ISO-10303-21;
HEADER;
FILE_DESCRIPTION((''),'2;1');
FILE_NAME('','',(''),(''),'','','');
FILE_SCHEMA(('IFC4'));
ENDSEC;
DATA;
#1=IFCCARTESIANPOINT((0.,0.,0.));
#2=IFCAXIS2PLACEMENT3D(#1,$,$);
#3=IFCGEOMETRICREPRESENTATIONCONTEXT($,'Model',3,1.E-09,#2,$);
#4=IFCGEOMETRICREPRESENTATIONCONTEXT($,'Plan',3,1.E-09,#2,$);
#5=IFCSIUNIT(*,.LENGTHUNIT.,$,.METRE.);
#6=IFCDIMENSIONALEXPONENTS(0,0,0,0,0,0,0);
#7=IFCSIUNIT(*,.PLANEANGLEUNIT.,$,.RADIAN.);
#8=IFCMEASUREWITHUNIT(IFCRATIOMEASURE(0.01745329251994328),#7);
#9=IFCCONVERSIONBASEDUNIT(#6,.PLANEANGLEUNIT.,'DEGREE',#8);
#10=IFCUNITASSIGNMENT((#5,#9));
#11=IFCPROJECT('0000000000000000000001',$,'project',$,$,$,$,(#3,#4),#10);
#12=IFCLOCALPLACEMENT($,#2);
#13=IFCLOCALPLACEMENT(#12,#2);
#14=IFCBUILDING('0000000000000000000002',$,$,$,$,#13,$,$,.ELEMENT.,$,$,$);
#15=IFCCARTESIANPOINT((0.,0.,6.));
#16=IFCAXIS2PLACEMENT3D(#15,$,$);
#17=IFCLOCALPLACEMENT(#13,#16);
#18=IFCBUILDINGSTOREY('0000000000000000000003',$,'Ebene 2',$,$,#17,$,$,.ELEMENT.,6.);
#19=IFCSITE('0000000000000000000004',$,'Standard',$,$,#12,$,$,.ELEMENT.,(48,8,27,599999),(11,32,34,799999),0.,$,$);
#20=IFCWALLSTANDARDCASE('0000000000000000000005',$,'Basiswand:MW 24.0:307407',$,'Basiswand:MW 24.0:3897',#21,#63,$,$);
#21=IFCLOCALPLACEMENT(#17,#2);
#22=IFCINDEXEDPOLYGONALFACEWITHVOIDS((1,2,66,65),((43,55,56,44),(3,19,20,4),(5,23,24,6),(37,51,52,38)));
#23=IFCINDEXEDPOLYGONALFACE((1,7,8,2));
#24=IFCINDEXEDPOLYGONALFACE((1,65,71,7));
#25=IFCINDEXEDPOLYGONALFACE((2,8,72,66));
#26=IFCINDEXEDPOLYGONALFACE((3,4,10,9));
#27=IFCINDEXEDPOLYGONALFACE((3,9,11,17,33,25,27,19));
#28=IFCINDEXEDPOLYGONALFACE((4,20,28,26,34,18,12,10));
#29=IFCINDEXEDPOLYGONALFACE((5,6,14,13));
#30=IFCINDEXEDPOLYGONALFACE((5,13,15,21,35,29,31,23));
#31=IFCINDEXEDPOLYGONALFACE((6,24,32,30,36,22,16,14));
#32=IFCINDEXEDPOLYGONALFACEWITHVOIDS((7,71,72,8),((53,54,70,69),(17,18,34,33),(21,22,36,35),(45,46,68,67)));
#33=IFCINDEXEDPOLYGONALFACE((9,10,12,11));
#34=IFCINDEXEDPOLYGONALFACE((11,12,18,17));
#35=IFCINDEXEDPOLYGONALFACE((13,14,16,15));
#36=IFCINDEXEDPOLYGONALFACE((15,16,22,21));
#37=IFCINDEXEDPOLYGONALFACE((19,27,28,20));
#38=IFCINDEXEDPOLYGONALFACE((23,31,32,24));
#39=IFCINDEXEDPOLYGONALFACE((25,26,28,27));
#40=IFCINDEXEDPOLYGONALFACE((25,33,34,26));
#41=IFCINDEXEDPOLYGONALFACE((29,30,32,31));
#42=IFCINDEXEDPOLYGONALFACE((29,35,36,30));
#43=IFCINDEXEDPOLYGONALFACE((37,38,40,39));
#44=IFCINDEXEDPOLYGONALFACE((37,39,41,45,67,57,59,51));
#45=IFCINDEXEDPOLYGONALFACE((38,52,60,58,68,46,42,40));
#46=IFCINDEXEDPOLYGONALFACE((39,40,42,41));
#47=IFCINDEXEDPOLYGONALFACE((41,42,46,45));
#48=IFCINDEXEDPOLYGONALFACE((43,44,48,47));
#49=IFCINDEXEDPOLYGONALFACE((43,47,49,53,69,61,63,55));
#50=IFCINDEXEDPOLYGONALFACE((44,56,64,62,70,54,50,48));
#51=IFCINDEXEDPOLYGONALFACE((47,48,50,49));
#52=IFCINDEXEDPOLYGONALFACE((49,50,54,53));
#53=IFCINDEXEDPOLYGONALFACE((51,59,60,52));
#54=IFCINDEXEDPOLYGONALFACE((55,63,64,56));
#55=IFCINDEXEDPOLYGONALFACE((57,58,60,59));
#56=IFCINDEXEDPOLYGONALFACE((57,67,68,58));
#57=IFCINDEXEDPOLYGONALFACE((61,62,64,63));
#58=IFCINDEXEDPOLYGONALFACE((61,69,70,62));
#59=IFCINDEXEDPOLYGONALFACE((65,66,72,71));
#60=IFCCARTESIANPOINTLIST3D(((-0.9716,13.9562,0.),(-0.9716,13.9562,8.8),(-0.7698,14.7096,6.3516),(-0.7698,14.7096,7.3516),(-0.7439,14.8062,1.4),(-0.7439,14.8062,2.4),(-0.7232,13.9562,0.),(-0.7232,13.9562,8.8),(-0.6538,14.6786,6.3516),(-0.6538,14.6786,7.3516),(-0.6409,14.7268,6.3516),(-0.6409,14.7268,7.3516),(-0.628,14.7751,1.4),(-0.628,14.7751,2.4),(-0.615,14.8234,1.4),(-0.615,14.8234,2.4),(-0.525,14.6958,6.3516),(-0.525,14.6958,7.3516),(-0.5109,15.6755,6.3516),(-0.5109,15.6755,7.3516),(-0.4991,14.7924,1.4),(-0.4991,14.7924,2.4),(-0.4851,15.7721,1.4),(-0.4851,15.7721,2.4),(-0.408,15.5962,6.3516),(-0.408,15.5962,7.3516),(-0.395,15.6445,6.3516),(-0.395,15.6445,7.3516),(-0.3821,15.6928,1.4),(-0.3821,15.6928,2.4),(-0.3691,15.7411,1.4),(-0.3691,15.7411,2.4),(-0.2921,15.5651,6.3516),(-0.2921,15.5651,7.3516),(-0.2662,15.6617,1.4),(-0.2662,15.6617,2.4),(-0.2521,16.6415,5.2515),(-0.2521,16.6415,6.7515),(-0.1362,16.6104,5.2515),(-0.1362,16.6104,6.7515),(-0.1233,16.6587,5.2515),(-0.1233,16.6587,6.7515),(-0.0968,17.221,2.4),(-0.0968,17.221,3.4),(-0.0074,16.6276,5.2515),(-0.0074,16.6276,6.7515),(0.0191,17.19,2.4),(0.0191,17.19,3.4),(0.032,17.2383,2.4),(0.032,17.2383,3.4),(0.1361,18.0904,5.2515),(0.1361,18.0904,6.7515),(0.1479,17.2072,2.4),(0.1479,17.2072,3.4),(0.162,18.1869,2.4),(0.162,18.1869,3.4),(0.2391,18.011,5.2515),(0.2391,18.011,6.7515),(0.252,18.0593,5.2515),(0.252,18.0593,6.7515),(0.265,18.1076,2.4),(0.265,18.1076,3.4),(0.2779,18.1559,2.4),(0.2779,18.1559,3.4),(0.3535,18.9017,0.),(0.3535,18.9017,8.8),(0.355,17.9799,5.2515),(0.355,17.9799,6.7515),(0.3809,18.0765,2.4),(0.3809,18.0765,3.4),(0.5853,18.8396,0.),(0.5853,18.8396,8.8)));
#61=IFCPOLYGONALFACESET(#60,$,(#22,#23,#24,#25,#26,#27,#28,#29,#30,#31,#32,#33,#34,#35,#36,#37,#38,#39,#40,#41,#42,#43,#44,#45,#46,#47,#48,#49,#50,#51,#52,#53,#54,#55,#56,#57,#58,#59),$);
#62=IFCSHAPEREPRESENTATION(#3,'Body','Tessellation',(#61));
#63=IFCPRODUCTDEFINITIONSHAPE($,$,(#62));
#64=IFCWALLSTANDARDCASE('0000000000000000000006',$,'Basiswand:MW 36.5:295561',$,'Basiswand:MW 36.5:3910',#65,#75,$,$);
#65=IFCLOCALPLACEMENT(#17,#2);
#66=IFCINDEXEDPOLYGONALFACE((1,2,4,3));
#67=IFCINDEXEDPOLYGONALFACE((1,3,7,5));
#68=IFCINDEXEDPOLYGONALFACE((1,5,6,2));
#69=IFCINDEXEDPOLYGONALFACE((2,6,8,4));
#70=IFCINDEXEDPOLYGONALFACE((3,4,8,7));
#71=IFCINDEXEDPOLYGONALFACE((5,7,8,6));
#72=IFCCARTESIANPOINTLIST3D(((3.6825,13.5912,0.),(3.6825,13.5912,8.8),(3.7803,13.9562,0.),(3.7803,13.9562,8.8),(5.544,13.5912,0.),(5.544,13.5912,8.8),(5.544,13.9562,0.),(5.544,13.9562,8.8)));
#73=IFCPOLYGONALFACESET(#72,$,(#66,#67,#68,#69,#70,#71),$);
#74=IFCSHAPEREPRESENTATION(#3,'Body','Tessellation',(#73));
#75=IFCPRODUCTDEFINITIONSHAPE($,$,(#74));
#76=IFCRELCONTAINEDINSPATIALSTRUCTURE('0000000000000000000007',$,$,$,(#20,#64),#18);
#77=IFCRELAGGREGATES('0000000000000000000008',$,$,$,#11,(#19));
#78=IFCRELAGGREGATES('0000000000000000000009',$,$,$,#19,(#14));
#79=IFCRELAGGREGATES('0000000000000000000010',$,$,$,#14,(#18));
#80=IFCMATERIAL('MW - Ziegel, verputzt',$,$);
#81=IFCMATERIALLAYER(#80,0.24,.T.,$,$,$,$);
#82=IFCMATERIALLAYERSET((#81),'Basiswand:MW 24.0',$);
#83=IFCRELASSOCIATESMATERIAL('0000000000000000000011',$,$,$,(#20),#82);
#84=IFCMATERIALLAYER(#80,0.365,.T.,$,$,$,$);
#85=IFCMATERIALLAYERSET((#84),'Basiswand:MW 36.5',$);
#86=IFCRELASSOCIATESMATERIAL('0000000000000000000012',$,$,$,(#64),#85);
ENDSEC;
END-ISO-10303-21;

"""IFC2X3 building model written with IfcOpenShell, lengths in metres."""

from ifc_helpers import new_model, entity, si_unit, converted_unit, frame, origin, place, context, project, spatial, polyline, outline, extrude, clip, bounded_halfspace, material, layer, layer_set, layer_usage, element, save


model = new_model("IFC2X3")

# Units and contexts
model_context = context("Model", 3, precision=1e-09, world=origin())
plan_context = context("Plan", 3, precision=1e-09, world=origin())
ifc_project = project(units=[si_unit("LENGTHUNIT", "METRE"), converted_unit("PLANEANGLEUNIT", "DEGREE", entity("IfcRatioMeasure", 0.01745329251994328), si_unit("PLANEANGLEUNIT", "RADIAN"), dimensions=[0, 0, 0, 0, 0, 0, 0])], contexts=[model_context, plan_context])

# Site, building, storey
site_placement = place(None, origin())
site = spatial("IfcSite", under=ifc_project, at=site_placement, Name="Standard", CompositionType="ELEMENT", RefLatitude=(48, 8, 27, 599999), RefLongitude=(11, 32, 34, 799999), RefElevation=0.0)
building_placement = place(site_placement, origin())
building = spatial("IfcBuilding", under=site, at=building_placement, CompositionType="ELEMENT")
storey_placement = place(building_placement, frame((0.0, 0.0, 6.0)))
storey = spatial("IfcBuildingStorey", under=building, at=storey_placement, Name="Ebene 2", CompositionType="ELEMENT", Elevation=6.0)

# Shared definitions
ifc_material = material(Name="MW - Ziegel, verputzt")
ifc_layer_1 = layer(ifc_material, 0.24, ventilated=True)
ifc_layer_set_1 = layer_set([ifc_layer_1], Name="Basiswand:MW 24.0")

# Shared definitions
ifc_layer_2 = layer(ifc_material, 0.365, ventilated=True)
ifc_layer_set_2 = layer_set([ifc_layer_2], Name="Basiswand:MW 36.5")

# Wall, openings
ifc_layer_usage_1 = layer_usage(ifc_layer_set_1, "AXIS2", "NEGATIVE", 0.12)
wall_1_placement = place(storey_placement, frame((-0.8557, 13.9251, 0.0), z_axis=(0.0, 0.0, 1.0), x_axis=(0.258819, 0.965926, 0.0)))
wall_1 = element("IfcWallStandardCase", 1, at=wall_1_placement, inside=storey, material=ifc_layer_usage_1, Name="Basiswand:MW 24.0:307407", ObjectType="Basiswand:MW 24.0:3897", context=model_context, shape_type="Clipping", body=[
    clip(extrude(outline(polyline([(5.12, -0.12), (5.12, 0.12), (0.0, 0.12), (0.0643, -0.12), (5.12, -0.12)])), origin(), (0.0, 0.0, 1.0), 8.8), bounded_halfspace(frame((0.0643, -0.12, 8.8), z_axis=(0.0, 0.0, -1.0), x_axis=(0.0, -1.0, 0.0)), True, frame((0.0643, -0.12, 8.8)), polyline([(0.0, 0.0), (4.9655, 0.0), (4.9655, 0.24), (-0.0643, 0.24), (0.0, 0.0)]))),
])
opening_1_placement = place(wall_1_placement, origin())
element("IfcOpeningElement", 2, at=opening_1_placement, cuts=wall_1, ObjectType="Opening", context=model_context, shape_type="SweptSolid", body=[
    extrude(outline(polyline([(-0.7, -0.28), (0.7, -0.28), (0.7, -0.03), (0.75, -0.03), (0.75, 0.34), (-0.75, 0.34), (-0.75, -0.03), (-0.7, -0.03), (-0.7, -0.28)])), frame((3.53, 0.03, 5.2515)), (0.0, 0.0, 1.0), 1.5),
])
opening_2_placement = place(wall_1_placement, origin())
element("IfcOpeningElement", 3, at=opening_2_placement, cuts=wall_1, ObjectType="Opening", context=model_context, shape_type="SweptSolid", body=[
    extrude(outline(polyline([(-0.45, -0.28), (0.45, -0.28), (0.45, -0.03), (0.5, -0.03), (0.5, 0.34), (-0.5, 0.34), (-0.5, -0.03), (-0.45, -0.03), (-0.45, -0.28)])), frame((3.88, 0.03, 2.4)), (0.0, 0.0, 1.0), 1.0),
])
opening_3_placement = place(wall_1_placement, origin())
element("IfcOpeningElement", 4, at=opening_3_placement, cuts=wall_1, ObjectType="Opening", context=model_context, shape_type="SweptSolid", body=[
    extrude(outline(polyline([(-0.45, -0.28), (0.45, -0.28), (0.45, -0.03), (0.5, -0.03), (0.5, 0.34), (-0.5, 0.34), (-0.5, -0.03), (-0.45, -0.03), (-0.45, -0.28)])), frame((1.38, 0.03, 1.4)), (0.0, 0.0, 1.0), 1.0),
])
opening_4_placement = place(wall_1_placement, origin())
element("IfcOpeningElement", 5, at=opening_4_placement, cuts=wall_1, ObjectType="Opening", context=model_context, shape_type="SweptSolid", body=[
    extrude(outline(polyline([(-0.45, -0.28), (0.45, -0.28), (0.45, -0.03), (0.5, -0.03), (0.5, 0.34), (-0.5, 0.34), (-0.5, -0.03), (-0.45, -0.03), (-0.45, -0.28)])), frame((1.28, 0.03, 6.3516)), (0.0, 0.0, 1.0), 1.0),
])

# Wall
ifc_layer_usage_2 = layer_usage(ifc_layer_set_2, "AXIS2", "NEGATIVE", 0.1825)
wall_2_placement = place(storey_placement, frame((5.544, 13.7737, 0.0), z_axis=(0.0, 0.0, 1.0), x_axis=(-1.0, 0.0, 0.0)))
element("IfcWallStandardCase", 6, at=wall_2_placement, inside=storey, material=ifc_layer_usage_2, Name="Basiswand:MW 36.5:295561", ObjectType="Basiswand:MW 36.5:3910", context=model_context, shape_type="SweptSolid", body=[
    extrude(outline(polyline([(1.7637, -0.1825), (1.8615, 0.1825), (0.0, 0.1825), (0.0, -0.1825), (1.7637, -0.1825)])), origin(), (0.0, 0.0, 1.0), 8.8),
])

save(model, "model.ifc")
